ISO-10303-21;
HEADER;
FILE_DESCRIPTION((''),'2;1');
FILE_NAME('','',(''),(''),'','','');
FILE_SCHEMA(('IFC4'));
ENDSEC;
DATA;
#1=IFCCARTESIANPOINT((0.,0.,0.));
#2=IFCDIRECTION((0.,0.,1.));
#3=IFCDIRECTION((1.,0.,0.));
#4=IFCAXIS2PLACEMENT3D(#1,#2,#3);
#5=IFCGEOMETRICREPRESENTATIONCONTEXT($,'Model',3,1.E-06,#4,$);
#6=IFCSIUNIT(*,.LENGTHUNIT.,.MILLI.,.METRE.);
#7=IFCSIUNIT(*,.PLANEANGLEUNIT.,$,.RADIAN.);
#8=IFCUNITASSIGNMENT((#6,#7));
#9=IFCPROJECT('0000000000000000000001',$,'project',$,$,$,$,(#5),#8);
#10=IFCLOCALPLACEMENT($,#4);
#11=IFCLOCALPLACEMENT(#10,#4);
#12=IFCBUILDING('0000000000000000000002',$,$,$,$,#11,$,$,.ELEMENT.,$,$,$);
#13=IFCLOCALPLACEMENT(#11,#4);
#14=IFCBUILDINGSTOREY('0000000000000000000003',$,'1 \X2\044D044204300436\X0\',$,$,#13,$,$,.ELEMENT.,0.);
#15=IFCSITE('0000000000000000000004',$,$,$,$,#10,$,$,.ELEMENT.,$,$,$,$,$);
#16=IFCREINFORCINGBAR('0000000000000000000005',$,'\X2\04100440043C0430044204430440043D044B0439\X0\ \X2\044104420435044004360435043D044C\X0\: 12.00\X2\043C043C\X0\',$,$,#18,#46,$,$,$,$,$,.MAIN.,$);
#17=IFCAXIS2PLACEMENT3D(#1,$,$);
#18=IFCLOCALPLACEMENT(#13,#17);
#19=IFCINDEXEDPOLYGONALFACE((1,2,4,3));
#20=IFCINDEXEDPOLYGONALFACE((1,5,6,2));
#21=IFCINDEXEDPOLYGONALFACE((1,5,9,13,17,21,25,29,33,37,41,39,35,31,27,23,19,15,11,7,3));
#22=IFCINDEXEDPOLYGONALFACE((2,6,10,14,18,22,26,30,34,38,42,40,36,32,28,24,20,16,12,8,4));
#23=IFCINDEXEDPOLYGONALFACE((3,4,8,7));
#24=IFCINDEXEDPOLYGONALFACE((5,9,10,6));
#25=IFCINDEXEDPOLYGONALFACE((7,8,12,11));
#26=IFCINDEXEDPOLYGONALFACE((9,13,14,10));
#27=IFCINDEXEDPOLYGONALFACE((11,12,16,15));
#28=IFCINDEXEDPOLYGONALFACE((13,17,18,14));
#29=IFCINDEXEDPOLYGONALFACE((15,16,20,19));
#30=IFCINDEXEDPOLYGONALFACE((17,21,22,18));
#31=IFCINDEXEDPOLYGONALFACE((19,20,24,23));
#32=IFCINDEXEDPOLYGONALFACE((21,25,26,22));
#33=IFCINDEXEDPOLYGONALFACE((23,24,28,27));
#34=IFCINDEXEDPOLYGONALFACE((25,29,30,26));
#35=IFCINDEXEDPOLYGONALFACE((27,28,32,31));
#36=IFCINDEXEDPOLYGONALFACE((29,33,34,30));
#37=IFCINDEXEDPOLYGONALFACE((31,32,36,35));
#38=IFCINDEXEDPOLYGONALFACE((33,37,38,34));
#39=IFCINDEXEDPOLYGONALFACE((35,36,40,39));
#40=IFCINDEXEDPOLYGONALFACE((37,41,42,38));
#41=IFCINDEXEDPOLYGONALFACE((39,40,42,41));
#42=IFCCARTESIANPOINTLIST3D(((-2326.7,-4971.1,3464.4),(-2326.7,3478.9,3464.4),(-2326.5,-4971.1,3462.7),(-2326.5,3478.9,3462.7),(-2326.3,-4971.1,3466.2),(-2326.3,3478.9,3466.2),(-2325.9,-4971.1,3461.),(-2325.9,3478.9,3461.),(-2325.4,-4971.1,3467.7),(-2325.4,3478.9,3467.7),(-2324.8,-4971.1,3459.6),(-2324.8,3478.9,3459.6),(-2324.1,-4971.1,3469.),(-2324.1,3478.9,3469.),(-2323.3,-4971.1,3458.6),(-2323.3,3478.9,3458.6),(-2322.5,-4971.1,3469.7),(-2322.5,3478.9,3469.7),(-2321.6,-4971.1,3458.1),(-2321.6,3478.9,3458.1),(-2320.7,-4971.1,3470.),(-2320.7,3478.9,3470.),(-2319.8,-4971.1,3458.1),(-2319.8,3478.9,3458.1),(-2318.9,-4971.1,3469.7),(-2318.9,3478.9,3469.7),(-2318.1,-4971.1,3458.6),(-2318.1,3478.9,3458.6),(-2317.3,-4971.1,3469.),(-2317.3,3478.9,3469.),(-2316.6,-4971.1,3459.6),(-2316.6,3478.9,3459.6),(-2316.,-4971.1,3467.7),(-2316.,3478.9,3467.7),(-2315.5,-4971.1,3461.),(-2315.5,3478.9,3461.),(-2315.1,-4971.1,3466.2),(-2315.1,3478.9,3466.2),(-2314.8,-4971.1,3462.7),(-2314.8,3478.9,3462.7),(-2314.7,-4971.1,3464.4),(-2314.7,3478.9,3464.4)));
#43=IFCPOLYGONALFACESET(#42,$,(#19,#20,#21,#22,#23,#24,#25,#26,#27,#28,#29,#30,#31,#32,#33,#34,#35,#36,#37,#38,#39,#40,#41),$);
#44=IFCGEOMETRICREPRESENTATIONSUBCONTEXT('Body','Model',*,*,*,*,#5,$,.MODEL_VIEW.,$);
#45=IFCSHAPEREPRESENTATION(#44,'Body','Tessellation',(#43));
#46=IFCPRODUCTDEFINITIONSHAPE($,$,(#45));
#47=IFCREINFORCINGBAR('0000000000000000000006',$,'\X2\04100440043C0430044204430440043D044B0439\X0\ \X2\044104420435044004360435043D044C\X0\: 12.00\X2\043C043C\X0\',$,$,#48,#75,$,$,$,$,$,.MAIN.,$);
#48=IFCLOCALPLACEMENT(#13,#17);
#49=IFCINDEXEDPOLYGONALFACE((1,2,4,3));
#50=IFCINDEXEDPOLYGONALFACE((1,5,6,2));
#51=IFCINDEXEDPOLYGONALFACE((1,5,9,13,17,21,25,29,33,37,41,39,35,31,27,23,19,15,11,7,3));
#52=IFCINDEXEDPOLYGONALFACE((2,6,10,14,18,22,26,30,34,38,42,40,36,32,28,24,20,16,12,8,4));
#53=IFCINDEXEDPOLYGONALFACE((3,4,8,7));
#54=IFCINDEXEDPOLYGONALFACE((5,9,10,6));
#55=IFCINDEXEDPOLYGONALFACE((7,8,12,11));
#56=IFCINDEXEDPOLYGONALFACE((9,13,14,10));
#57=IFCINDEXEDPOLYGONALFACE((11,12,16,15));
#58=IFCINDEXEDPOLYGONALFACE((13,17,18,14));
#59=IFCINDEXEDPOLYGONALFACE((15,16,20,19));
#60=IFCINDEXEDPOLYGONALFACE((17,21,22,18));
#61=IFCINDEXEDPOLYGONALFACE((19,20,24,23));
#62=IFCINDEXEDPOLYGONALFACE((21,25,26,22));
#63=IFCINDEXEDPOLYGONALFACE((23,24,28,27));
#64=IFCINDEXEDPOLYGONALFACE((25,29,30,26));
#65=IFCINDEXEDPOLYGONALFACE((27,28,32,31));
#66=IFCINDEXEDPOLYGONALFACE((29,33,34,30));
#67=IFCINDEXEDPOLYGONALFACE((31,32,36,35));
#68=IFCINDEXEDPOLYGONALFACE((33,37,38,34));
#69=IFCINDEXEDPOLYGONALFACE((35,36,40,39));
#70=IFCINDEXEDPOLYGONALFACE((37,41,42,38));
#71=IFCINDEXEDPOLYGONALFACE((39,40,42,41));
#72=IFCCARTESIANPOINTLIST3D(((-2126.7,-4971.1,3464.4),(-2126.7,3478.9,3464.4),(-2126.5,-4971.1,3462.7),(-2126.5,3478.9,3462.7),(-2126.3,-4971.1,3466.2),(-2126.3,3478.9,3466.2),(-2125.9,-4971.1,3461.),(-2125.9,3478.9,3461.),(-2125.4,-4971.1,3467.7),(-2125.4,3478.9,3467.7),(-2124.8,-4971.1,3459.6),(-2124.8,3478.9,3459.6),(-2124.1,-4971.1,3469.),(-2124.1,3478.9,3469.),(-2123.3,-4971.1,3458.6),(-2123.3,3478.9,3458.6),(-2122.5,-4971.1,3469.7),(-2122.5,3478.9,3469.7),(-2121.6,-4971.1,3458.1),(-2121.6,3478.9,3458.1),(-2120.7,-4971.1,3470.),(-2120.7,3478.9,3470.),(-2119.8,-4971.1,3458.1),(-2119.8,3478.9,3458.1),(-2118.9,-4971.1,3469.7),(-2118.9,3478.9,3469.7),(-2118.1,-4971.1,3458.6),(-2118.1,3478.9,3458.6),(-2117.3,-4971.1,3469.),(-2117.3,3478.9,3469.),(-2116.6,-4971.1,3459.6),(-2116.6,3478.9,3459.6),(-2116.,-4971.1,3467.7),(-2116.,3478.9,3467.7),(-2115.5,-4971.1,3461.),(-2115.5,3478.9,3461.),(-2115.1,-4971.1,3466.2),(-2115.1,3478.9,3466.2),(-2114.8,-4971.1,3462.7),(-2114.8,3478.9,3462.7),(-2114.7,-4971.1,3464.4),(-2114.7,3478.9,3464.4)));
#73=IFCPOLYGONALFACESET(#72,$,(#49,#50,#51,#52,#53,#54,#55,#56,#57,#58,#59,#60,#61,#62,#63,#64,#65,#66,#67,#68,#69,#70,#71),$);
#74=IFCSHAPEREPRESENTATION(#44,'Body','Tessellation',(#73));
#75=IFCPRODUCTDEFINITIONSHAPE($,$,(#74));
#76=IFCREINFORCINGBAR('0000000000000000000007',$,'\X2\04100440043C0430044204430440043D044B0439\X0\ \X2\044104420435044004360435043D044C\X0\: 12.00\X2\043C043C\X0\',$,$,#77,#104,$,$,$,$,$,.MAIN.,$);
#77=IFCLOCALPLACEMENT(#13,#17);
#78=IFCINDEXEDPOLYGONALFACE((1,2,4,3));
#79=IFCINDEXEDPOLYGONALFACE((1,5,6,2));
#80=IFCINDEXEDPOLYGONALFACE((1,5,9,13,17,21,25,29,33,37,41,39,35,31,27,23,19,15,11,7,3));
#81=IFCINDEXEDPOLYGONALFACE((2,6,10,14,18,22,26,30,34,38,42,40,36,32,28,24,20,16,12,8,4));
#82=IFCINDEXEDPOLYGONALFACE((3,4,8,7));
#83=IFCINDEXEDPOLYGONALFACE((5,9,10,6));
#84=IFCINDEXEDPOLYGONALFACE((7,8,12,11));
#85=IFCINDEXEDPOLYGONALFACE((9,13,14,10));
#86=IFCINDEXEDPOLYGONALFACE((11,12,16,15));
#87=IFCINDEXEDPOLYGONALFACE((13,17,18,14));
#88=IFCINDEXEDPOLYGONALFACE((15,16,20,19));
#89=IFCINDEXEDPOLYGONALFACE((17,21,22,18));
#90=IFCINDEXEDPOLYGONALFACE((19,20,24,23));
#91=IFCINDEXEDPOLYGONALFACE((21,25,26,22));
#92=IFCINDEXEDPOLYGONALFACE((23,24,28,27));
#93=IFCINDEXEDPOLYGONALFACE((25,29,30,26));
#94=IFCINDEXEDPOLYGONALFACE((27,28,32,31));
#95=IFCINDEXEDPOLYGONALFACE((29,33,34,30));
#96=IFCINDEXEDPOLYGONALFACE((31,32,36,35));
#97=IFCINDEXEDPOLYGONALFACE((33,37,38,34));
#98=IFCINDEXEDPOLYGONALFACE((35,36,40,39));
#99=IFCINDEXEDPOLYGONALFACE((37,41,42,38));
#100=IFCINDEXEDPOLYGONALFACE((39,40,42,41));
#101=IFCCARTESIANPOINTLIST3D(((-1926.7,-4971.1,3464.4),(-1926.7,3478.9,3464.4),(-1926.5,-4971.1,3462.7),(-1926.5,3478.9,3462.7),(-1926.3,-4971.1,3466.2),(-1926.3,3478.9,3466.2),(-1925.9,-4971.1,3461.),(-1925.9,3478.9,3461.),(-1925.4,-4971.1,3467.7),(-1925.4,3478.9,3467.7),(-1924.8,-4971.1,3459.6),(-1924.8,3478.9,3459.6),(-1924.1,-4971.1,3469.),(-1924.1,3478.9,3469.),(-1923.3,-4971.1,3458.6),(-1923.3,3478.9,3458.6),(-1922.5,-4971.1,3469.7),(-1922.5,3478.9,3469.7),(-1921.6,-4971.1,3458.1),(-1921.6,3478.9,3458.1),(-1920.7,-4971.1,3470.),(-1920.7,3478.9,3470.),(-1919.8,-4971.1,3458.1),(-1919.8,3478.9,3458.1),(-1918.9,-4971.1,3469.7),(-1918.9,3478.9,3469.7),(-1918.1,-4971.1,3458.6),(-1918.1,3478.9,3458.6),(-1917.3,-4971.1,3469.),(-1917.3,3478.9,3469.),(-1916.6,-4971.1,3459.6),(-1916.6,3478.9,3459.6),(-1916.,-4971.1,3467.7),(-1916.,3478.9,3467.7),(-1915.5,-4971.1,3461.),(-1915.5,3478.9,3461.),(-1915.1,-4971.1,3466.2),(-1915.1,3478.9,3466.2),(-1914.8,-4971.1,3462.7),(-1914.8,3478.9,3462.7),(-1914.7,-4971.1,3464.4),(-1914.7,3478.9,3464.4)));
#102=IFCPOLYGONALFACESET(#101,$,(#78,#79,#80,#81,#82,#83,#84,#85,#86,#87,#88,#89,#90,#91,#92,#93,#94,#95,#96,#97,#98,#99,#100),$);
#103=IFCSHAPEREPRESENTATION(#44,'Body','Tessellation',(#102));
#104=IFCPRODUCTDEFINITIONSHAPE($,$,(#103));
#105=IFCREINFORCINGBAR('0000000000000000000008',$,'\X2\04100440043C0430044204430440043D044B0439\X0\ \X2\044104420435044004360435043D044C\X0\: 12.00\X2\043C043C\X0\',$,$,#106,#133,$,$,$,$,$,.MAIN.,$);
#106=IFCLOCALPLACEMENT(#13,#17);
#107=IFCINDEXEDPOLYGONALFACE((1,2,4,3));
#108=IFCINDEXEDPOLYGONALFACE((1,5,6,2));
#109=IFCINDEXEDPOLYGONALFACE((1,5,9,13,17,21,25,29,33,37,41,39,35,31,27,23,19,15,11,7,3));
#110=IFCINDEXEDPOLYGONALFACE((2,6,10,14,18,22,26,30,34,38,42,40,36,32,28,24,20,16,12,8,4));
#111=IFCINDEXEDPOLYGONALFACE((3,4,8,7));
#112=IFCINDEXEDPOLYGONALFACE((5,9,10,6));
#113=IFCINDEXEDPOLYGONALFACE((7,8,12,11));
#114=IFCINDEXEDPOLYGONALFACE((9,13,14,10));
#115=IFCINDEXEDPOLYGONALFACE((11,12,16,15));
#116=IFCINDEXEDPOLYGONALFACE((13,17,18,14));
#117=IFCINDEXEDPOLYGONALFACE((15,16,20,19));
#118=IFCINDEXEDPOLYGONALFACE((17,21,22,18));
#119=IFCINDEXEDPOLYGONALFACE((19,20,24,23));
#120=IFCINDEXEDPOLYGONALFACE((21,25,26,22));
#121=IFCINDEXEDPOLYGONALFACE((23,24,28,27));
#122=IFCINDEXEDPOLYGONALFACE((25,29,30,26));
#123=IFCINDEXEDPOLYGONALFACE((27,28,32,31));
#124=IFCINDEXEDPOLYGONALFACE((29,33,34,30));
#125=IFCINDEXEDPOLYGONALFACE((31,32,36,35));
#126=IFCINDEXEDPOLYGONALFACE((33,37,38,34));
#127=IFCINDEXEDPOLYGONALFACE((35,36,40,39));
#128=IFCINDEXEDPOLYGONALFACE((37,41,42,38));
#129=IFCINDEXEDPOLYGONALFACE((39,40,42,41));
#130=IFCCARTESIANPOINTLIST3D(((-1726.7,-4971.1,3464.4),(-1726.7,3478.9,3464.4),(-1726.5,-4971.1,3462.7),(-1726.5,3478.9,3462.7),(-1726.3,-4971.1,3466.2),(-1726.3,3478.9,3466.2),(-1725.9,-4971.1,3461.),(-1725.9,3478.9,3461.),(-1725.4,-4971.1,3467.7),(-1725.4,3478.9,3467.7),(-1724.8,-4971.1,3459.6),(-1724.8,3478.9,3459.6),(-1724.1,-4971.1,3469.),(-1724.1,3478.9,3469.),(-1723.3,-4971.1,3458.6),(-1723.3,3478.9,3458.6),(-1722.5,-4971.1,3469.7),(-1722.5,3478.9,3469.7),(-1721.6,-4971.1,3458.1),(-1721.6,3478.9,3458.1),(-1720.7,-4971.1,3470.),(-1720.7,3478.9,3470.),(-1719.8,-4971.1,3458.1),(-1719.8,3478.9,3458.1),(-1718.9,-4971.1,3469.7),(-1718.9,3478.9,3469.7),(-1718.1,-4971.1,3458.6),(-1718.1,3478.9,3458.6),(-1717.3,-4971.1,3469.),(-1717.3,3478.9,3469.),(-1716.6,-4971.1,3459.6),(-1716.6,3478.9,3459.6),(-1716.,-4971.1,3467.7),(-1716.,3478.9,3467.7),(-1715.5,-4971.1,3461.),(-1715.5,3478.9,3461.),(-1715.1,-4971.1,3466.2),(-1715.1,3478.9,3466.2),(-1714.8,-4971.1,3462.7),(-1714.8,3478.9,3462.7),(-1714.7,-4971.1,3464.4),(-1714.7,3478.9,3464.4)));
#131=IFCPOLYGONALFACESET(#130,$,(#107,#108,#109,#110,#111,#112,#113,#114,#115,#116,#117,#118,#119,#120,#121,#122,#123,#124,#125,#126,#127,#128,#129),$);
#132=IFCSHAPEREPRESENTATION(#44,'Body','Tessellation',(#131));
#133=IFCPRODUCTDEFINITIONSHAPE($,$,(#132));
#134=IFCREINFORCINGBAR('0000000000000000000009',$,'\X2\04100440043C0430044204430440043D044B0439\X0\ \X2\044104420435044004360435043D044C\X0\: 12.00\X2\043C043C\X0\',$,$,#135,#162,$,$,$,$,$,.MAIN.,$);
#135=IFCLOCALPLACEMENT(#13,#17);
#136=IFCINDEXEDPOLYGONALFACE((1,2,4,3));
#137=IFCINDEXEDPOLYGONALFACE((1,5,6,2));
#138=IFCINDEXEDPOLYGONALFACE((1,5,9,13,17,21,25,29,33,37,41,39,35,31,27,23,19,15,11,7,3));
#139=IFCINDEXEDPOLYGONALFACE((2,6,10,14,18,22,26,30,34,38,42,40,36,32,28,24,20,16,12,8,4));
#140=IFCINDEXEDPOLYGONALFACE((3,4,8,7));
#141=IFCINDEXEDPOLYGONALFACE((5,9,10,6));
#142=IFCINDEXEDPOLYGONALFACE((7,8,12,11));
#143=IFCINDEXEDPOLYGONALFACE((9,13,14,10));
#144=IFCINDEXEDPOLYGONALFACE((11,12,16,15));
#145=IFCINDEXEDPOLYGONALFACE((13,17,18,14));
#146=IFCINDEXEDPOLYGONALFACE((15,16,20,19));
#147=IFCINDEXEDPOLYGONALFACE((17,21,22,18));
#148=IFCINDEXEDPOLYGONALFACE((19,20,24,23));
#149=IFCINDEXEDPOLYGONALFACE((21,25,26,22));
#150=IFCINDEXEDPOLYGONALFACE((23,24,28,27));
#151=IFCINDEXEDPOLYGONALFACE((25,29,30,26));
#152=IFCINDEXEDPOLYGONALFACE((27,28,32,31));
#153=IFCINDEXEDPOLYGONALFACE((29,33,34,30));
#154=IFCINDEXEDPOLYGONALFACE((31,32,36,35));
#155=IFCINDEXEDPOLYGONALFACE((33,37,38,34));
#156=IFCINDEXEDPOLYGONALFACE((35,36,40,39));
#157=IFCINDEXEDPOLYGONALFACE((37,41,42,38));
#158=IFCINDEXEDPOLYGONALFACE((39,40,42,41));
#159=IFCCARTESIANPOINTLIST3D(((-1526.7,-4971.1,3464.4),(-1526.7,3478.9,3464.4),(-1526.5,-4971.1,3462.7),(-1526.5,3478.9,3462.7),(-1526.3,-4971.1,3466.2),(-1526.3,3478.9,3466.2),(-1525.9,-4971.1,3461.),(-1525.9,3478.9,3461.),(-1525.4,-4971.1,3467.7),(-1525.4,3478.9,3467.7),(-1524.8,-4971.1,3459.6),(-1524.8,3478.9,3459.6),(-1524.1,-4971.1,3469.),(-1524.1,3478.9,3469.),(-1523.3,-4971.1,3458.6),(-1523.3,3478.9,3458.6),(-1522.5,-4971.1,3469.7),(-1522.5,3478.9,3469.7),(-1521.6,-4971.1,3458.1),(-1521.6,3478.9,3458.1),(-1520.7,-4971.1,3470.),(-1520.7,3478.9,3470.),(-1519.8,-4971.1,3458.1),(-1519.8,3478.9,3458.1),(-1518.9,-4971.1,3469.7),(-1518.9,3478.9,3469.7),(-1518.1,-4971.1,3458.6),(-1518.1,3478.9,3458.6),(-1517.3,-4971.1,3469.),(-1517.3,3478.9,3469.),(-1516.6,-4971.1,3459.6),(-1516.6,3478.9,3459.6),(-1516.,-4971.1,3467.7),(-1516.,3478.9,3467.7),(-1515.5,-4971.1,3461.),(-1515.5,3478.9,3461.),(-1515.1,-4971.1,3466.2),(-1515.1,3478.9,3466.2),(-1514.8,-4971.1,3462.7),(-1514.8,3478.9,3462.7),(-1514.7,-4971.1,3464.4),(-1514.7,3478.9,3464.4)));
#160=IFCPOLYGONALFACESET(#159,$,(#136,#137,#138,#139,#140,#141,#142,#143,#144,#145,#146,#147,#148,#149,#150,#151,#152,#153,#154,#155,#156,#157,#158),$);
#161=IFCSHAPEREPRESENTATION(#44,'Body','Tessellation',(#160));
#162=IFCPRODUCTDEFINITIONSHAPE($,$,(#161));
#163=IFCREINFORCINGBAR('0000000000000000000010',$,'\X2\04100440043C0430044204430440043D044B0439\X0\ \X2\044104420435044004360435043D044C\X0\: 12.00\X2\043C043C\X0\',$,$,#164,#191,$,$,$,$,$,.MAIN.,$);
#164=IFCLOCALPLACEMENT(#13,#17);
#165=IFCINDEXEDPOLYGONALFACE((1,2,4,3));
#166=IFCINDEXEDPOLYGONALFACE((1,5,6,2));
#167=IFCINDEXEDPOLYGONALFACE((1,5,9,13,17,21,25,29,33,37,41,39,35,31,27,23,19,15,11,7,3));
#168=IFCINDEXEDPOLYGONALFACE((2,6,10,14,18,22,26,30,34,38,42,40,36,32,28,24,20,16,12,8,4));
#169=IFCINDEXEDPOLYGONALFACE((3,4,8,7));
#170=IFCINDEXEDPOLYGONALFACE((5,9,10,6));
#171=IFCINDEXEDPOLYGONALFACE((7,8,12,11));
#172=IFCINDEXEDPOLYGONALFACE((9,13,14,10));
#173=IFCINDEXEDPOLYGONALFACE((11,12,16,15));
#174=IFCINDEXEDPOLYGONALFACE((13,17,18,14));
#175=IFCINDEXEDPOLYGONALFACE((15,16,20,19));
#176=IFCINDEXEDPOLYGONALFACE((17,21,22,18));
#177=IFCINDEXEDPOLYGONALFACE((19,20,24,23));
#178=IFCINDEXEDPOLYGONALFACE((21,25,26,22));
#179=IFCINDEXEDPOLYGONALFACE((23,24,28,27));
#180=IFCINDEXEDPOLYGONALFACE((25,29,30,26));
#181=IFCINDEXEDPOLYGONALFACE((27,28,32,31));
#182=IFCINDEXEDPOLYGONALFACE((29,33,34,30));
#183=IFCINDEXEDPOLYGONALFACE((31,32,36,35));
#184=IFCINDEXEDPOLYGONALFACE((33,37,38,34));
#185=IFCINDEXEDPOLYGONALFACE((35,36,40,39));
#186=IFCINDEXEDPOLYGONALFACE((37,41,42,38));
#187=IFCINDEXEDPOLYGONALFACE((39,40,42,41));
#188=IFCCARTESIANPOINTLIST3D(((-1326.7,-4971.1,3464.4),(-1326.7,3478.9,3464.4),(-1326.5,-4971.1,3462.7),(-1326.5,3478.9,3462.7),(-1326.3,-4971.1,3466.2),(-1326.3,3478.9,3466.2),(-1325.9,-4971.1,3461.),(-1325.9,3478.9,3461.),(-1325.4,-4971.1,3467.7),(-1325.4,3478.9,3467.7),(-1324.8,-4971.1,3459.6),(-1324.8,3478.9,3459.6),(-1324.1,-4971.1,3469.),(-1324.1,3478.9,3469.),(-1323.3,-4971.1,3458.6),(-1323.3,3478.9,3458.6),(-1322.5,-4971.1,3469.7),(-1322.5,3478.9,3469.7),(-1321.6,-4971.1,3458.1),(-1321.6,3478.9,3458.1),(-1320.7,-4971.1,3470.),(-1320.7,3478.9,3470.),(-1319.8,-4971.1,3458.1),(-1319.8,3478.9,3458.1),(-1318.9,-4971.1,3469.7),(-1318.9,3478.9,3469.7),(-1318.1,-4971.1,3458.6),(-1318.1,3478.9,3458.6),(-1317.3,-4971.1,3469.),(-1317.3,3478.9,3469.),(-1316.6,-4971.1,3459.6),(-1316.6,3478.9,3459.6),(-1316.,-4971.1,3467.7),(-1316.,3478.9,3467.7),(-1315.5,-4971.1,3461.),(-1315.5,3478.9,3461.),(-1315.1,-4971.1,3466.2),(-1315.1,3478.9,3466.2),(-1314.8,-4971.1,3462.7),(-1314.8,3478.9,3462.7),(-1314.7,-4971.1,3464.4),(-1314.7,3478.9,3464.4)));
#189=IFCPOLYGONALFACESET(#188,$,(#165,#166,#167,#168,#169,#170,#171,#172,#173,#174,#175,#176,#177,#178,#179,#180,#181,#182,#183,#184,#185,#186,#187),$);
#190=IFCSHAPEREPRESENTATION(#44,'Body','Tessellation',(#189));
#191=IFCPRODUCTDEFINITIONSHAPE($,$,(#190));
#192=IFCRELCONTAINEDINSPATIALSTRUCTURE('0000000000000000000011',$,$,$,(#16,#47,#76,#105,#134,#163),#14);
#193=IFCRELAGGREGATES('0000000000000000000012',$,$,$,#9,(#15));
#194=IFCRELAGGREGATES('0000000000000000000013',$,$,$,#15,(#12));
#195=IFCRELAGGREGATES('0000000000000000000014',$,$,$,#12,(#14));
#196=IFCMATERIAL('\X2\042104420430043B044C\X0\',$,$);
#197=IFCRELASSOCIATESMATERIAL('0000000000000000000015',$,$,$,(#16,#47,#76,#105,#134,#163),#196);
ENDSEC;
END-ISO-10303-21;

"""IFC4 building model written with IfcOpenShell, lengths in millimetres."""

from ifc_helpers import new_model, entity, si_unit, origin_with_axes, place, context, subcontext, project, spatial, source, transform, mapped, material, element, save


model = new_model("IFC4")

# Units and contexts
model_context = context("Model", 3, precision=1e-06, world=origin_with_axes())
body_context = subcontext(model_context, "Body", "Model", "MODEL_VIEW")
ifc_project = project(units=[si_unit("LENGTHUNIT", "METRE", prefix="MILLI"), si_unit("PLANEANGLEUNIT", "RADIAN")], contexts=[model_context])

# Site, building, storey
site_placement = place(None, origin_with_axes())
site = spatial("IfcSite", under=ifc_project, at=site_placement, CompositionType="ELEMENT")
building_placement = place(site_placement, origin_with_axes())
building = spatial("IfcBuilding", under=site, at=building_placement, CompositionType="ELEMENT")
storey_placement = place(building_placement, origin_with_axes())
storey = spatial("IfcBuildingStorey", under=building, at=storey_placement, Name="1 этаж", CompositionType="ELEMENT", Elevation=0.0)

# Reinforcing bars
ifc_material = material(Name="Сталь")
shared_shape = source(origin_with_axes(), body_context, "Body", "AdvancedSweptSolid", [
    entity("IfcSweptDiskSolid", entity("IfcIndexedPolyCurve", entity("IfcCartesianPointList3D", [[0.0, 0.0, 0.0], [8450.0, 0.0, 0.0]]), [entity("IfcLineIndex", [1, 2])]), 6.0),
])
reinforcing_bar_1_placement = place(storey_placement, origin_with_axes())
element("IfcReinforcingBar", 1, at=reinforcing_bar_1_placement, inside=storey, material=ifc_material, Name="Арматурный стержень: 12.00мм", PredefinedType="MAIN", context=body_context, shape_type="MappedRepresentation", body=[
    mapped(shared_shape, transform((-2320.7, -4971.1, 3464.0), x_axis=(0.0, 1.0, 0.0), y_axis=(-1.0, 0.0, 0.0), z_axis=(0.0, 0.0, 1.0), scale=1.0)),
])
reinforcing_bar_2_placement = place(storey_placement, origin_with_axes())
element("IfcReinforcingBar", 2, at=reinforcing_bar_2_placement, inside=storey, material=ifc_material, Name="Арматурный стержень: 12.00мм", PredefinedType="MAIN", context=body_context, shape_type="MappedRepresentation", body=[
    mapped(shared_shape, transform((-2120.7, -4971.1, 3464.0), x_axis=(0.0, 1.0, 0.0), y_axis=(-1.0, 0.0, 0.0), z_axis=(0.0, 0.0, 1.0), scale=1.0)),
])
reinforcing_bar_3_placement = place(storey_placement, origin_with_axes())
element("IfcReinforcingBar", 3, at=reinforcing_bar_3_placement, inside=storey, material=ifc_material, Name="Арматурный стержень: 12.00мм", PredefinedType="MAIN", context=body_context, shape_type="MappedRepresentation", body=[
    mapped(shared_shape, transform((-1920.7, -4971.1, 3464.0), x_axis=(0.0, 1.0, 0.0), y_axis=(-1.0, 0.0, 0.0), z_axis=(0.0, 0.0, 1.0), scale=1.0)),
])
reinforcing_bar_4_placement = place(storey_placement, origin_with_axes())
element("IfcReinforcingBar", 4, at=reinforcing_bar_4_placement, inside=storey, material=ifc_material, Name="Арматурный стержень: 12.00мм", PredefinedType="MAIN", context=body_context, shape_type="MappedRepresentation", body=[
    mapped(shared_shape, transform((-1720.7, -4971.1, 3464.0), x_axis=(0.0, 1.0, 0.0), y_axis=(-1.0, 0.0, 0.0), z_axis=(0.0, 0.0, 1.0), scale=1.0)),
])
reinforcing_bar_5_placement = place(storey_placement, origin_with_axes())
element("IfcReinforcingBar", 5, at=reinforcing_bar_5_placement, inside=storey, material=ifc_material, Name="Арматурный стержень: 12.00мм", PredefinedType="MAIN", context=body_context, shape_type="MappedRepresentation", body=[
    mapped(shared_shape, transform((-1520.7, -4971.1, 3464.0), x_axis=(0.0, 1.0, 0.0), y_axis=(-1.0, 0.0, 0.0), z_axis=(0.0, 0.0, 1.0), scale=1.0)),
])
reinforcing_bar_6_placement = place(storey_placement, origin_with_axes())
element("IfcReinforcingBar", 6, at=reinforcing_bar_6_placement, inside=storey, material=ifc_material, Name="Арматурный стержень: 12.00мм", PredefinedType="MAIN", context=body_context, shape_type="MappedRepresentation", body=[
    mapped(shared_shape, transform((-1320.7, -4971.1, 3464.0), x_axis=(0.0, 1.0, 0.0), y_axis=(-1.0, 0.0, 0.0), z_axis=(0.0, 0.0, 1.0), scale=1.0)),
])

save(model, "model.ifc")
